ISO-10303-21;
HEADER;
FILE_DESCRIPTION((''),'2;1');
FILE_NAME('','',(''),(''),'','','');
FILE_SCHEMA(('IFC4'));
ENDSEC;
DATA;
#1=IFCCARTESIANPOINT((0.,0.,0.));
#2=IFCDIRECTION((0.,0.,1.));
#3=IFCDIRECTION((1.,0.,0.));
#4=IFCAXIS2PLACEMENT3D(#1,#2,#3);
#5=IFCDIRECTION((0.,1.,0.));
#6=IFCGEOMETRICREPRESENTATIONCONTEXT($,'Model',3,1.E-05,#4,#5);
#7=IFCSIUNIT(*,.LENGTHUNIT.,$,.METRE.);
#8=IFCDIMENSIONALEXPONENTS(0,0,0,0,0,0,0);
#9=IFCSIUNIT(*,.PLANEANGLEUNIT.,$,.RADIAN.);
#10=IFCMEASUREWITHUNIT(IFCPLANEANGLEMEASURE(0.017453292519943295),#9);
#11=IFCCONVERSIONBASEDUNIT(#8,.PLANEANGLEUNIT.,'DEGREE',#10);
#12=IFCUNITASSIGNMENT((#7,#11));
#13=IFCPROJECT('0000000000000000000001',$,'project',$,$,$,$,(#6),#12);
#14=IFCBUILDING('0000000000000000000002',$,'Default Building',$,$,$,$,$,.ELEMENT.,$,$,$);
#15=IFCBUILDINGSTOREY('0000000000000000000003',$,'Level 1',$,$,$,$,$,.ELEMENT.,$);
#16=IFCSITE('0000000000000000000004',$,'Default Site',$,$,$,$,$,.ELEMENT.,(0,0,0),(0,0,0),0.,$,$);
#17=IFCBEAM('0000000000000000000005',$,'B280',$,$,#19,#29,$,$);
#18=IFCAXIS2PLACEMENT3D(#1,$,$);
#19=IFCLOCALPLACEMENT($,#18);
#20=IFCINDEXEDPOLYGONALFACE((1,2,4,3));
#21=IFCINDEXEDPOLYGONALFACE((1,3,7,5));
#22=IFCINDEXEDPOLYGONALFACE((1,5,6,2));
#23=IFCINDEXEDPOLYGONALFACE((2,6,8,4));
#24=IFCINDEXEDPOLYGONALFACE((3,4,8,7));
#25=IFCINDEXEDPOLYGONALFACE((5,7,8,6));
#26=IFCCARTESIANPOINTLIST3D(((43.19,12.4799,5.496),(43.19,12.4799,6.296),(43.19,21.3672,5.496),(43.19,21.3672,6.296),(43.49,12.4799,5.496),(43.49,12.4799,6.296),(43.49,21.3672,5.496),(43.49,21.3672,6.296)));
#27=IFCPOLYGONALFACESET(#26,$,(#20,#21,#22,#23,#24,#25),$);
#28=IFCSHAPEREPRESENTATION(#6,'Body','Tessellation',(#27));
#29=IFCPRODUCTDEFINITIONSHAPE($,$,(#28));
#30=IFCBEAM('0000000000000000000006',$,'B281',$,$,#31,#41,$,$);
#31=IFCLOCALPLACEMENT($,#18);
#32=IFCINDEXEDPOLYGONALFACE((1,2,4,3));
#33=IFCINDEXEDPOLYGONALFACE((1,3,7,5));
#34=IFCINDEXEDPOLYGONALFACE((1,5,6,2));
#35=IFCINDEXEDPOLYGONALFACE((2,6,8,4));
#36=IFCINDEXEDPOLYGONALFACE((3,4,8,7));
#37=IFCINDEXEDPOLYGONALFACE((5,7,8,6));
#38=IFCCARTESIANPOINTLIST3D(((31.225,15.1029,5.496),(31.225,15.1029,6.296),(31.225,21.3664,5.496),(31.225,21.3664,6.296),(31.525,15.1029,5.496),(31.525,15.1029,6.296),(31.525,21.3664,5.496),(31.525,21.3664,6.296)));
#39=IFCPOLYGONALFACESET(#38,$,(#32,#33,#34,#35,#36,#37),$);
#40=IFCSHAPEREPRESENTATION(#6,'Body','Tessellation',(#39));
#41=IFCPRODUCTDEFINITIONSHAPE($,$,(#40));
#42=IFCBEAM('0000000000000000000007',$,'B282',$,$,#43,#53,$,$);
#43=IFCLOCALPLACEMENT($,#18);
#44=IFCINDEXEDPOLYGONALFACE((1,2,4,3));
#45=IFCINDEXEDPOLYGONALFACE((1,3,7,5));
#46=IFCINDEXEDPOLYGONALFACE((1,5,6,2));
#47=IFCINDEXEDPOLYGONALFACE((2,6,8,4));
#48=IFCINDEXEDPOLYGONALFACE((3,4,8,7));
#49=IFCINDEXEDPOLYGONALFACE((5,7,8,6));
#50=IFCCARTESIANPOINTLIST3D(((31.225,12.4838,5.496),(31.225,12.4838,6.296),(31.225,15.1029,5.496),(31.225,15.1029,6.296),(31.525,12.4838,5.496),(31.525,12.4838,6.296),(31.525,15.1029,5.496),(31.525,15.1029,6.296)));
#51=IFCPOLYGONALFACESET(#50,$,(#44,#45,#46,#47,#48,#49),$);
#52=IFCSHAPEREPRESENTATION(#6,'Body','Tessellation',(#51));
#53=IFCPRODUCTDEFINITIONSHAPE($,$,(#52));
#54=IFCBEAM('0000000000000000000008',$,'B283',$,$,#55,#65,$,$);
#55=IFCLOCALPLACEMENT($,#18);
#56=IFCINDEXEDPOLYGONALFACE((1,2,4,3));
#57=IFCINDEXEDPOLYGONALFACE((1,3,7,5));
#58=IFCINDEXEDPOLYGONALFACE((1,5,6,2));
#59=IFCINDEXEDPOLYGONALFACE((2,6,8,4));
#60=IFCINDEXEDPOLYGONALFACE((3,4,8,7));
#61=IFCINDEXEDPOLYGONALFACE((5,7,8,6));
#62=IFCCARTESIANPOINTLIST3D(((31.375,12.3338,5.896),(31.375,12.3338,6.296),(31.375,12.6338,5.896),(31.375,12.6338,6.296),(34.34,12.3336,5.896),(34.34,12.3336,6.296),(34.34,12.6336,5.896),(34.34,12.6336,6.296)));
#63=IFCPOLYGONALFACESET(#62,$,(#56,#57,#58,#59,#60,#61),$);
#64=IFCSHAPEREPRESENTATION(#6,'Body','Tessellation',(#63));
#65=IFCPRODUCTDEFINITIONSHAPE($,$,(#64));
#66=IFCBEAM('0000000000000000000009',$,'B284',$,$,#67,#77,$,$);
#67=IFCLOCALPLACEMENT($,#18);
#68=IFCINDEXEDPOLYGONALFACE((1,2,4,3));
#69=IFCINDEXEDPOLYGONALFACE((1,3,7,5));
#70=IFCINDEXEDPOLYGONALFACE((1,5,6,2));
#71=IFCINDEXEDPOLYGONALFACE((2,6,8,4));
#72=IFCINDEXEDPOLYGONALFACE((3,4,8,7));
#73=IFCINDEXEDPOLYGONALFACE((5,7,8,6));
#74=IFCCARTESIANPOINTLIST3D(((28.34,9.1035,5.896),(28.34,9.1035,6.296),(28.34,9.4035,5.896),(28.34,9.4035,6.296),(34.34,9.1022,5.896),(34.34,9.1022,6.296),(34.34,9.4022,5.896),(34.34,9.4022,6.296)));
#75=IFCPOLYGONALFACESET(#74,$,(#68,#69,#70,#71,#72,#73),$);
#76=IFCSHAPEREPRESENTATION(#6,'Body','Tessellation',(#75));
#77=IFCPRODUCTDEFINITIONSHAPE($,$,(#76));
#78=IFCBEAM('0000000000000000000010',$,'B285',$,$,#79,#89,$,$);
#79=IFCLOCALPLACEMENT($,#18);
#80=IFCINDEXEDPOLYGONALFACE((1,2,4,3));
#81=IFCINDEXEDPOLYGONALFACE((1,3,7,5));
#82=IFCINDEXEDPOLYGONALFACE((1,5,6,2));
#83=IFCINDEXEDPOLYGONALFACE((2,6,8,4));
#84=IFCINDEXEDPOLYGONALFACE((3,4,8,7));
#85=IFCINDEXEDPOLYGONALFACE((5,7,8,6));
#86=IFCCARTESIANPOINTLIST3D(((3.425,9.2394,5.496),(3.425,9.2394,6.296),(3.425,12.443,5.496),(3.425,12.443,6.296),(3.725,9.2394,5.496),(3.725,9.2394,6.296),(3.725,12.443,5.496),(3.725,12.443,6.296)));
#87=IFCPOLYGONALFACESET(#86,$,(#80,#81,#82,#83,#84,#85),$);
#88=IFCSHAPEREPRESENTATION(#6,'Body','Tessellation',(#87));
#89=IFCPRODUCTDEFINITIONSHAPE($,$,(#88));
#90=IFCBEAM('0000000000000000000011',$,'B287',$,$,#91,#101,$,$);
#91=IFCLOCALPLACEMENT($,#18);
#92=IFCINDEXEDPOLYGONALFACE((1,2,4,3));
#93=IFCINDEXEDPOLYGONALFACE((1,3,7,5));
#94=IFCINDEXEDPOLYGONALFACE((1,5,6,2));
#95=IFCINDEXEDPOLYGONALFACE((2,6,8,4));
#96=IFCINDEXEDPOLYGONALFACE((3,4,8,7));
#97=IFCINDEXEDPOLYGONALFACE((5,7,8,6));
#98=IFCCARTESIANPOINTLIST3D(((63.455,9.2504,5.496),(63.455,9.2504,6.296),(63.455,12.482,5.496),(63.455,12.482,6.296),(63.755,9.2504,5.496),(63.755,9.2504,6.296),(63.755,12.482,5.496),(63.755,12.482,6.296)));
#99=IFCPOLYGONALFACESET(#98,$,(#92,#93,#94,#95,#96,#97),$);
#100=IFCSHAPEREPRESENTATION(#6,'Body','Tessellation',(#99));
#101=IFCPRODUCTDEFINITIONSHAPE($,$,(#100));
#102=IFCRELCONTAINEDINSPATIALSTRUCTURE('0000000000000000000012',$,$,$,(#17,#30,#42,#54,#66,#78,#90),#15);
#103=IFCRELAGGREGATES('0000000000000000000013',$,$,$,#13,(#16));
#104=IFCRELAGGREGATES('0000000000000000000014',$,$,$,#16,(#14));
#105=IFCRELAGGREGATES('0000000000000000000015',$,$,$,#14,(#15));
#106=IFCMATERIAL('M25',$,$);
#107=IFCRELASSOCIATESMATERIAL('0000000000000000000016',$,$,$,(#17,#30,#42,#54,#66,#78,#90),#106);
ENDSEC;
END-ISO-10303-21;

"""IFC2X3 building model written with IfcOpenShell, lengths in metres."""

from ifc_helpers import new_model, entity, si_unit, converted_unit, direction, frame, frame_2d, origin_with_axes, place, context, project, spatial, rectangle, extrude, material, element, save


model = new_model("IFC2X3")

# Units and contexts
model_context = context("Model", 3, precision=1e-05, world=origin_with_axes(), true_north=direction((0.0, 1.0, 0.0)))
ifc_project = project(units=[si_unit("LENGTHUNIT", "METRE"), converted_unit("PLANEANGLEUNIT", "DEGREE", entity("IfcPlaneAngleMeasure", 0.017453292519943295), si_unit("PLANEANGLEUNIT", "RADIAN"), dimensions=[0, 0, 0, 0, 0, 0, 0])], contexts=[model_context])

# Site, building, storey
site = spatial("IfcSite", under=ifc_project, Name="Default Site", CompositionType="ELEMENT", RefLatitude=(0, 0, 0), RefLongitude=(0, 0, 0), RefElevation=0.0)
building = spatial("IfcBuilding", under=site, Name="Default Building", CompositionType="ELEMENT")
storey = spatial("IfcBuildingStorey", under=building, Name="Level 1", CompositionType="ELEMENT")

# Beams
ifc_material = material(Name="M25")
placement = place(None, origin_with_axes())
element("IfcBeam", 1, at=placement, inside=storey, material=ifc_material, Name="B280", context=model_context, shape_type="SweptSolid", body=[
    extrude(rectangle(XDim=0.3, YDim=0.8, at=frame_2d((0.0, 0.0), x_axis=(0.0, 1.0, 0.0))), frame((43.34, 21.3672, 5.896), z_axis=(0.0, -1.0, 0.0), x_axis=(0.0, 0.0, -1.0)), (0.0, 0.0, 1.0), 8.8873),
])
element("IfcBeam", 2, at=placement, inside=storey, material=ifc_material, Name="B281", context=model_context, shape_type="SweptSolid", body=[
    extrude(rectangle(XDim=0.3, YDim=0.8, at=frame_2d((0.0, 0.0), x_axis=(0.0, 1.0, 0.0))), frame((31.375, 21.3664, 5.896), z_axis=(0.0, -1.0, 0.0), x_axis=(0.0, 0.0, -1.0)), (0.0, 0.0, 1.0), 6.2635),
])
element("IfcBeam", 3, at=placement, inside=storey, material=ifc_material, Name="B282", context=model_context, shape_type="SweptSolid", body=[
    extrude(rectangle(XDim=0.3, YDim=0.8, at=frame_2d((0.0, 0.0), x_axis=(0.0, 1.0, 0.0))), frame((31.375, 15.1029, 5.896), z_axis=(0.0, -1.0, 0.0), x_axis=(0.0, 0.0, -1.0)), (0.0, 0.0, 1.0), 2.6191),
])
element("IfcBeam", 4, at=placement, inside=storey, material=ifc_material, Name="B283", context=model_context, shape_type="SweptSolid", body=[
    extrude(rectangle(XDim=0.3, YDim=0.4, at=frame_2d((0.0, 0.0), x_axis=(0.0, 1.0, 0.0))), frame((31.375, 12.4838, 6.096), z_axis=(1.0, -0.000067, 0.0), x_axis=(0.0, 0.0, -1.0)), (0.0, 0.0, 1.0), 2.965),
])
element("IfcBeam", 5, at=placement, inside=storey, material=ifc_material, Name="B284", context=model_context, shape_type="SweptSolid", body=[
    extrude(rectangle(XDim=0.3, YDim=0.4, at=frame_2d((0.0, 0.0), x_axis=(0.0, 1.0, 0.0))), frame((28.34, 9.2535, 6.096), z_axis=(1.0, -0.000213, 0.0), x_axis=(0.0, 0.0, -1.0)), (0.0, 0.0, 1.0), 6.0),
])
element("IfcBeam", 6, at=placement, inside=storey, material=ifc_material, Name="B285", context=model_context, shape_type="SweptSolid", body=[
    extrude(rectangle(XDim=0.3, YDim=0.8, at=frame_2d((0.0, 0.0), x_axis=(0.0, 1.0, 0.0))), frame((3.575, 12.443, 5.896), z_axis=(0.0, -1.0, 0.0), x_axis=(0.0, 0.0, -1.0)), (0.0, 0.0, 1.0), 3.2036),
])
element("IfcBeam", 7, at=placement, inside=storey, material=ifc_material, Name="B287", context=model_context, shape_type="SweptSolid", body=[
    extrude(rectangle(XDim=0.3, YDim=0.8, at=frame_2d((0.0, 0.0), x_axis=(0.0, 1.0, 0.0))), frame((63.605, 12.482, 5.896), z_axis=(0.0, -1.0, 0.0), x_axis=(0.0, 0.0, -1.0)), (0.0, 0.0, 1.0), 3.2316),
])

save(model, "model.ifc")
